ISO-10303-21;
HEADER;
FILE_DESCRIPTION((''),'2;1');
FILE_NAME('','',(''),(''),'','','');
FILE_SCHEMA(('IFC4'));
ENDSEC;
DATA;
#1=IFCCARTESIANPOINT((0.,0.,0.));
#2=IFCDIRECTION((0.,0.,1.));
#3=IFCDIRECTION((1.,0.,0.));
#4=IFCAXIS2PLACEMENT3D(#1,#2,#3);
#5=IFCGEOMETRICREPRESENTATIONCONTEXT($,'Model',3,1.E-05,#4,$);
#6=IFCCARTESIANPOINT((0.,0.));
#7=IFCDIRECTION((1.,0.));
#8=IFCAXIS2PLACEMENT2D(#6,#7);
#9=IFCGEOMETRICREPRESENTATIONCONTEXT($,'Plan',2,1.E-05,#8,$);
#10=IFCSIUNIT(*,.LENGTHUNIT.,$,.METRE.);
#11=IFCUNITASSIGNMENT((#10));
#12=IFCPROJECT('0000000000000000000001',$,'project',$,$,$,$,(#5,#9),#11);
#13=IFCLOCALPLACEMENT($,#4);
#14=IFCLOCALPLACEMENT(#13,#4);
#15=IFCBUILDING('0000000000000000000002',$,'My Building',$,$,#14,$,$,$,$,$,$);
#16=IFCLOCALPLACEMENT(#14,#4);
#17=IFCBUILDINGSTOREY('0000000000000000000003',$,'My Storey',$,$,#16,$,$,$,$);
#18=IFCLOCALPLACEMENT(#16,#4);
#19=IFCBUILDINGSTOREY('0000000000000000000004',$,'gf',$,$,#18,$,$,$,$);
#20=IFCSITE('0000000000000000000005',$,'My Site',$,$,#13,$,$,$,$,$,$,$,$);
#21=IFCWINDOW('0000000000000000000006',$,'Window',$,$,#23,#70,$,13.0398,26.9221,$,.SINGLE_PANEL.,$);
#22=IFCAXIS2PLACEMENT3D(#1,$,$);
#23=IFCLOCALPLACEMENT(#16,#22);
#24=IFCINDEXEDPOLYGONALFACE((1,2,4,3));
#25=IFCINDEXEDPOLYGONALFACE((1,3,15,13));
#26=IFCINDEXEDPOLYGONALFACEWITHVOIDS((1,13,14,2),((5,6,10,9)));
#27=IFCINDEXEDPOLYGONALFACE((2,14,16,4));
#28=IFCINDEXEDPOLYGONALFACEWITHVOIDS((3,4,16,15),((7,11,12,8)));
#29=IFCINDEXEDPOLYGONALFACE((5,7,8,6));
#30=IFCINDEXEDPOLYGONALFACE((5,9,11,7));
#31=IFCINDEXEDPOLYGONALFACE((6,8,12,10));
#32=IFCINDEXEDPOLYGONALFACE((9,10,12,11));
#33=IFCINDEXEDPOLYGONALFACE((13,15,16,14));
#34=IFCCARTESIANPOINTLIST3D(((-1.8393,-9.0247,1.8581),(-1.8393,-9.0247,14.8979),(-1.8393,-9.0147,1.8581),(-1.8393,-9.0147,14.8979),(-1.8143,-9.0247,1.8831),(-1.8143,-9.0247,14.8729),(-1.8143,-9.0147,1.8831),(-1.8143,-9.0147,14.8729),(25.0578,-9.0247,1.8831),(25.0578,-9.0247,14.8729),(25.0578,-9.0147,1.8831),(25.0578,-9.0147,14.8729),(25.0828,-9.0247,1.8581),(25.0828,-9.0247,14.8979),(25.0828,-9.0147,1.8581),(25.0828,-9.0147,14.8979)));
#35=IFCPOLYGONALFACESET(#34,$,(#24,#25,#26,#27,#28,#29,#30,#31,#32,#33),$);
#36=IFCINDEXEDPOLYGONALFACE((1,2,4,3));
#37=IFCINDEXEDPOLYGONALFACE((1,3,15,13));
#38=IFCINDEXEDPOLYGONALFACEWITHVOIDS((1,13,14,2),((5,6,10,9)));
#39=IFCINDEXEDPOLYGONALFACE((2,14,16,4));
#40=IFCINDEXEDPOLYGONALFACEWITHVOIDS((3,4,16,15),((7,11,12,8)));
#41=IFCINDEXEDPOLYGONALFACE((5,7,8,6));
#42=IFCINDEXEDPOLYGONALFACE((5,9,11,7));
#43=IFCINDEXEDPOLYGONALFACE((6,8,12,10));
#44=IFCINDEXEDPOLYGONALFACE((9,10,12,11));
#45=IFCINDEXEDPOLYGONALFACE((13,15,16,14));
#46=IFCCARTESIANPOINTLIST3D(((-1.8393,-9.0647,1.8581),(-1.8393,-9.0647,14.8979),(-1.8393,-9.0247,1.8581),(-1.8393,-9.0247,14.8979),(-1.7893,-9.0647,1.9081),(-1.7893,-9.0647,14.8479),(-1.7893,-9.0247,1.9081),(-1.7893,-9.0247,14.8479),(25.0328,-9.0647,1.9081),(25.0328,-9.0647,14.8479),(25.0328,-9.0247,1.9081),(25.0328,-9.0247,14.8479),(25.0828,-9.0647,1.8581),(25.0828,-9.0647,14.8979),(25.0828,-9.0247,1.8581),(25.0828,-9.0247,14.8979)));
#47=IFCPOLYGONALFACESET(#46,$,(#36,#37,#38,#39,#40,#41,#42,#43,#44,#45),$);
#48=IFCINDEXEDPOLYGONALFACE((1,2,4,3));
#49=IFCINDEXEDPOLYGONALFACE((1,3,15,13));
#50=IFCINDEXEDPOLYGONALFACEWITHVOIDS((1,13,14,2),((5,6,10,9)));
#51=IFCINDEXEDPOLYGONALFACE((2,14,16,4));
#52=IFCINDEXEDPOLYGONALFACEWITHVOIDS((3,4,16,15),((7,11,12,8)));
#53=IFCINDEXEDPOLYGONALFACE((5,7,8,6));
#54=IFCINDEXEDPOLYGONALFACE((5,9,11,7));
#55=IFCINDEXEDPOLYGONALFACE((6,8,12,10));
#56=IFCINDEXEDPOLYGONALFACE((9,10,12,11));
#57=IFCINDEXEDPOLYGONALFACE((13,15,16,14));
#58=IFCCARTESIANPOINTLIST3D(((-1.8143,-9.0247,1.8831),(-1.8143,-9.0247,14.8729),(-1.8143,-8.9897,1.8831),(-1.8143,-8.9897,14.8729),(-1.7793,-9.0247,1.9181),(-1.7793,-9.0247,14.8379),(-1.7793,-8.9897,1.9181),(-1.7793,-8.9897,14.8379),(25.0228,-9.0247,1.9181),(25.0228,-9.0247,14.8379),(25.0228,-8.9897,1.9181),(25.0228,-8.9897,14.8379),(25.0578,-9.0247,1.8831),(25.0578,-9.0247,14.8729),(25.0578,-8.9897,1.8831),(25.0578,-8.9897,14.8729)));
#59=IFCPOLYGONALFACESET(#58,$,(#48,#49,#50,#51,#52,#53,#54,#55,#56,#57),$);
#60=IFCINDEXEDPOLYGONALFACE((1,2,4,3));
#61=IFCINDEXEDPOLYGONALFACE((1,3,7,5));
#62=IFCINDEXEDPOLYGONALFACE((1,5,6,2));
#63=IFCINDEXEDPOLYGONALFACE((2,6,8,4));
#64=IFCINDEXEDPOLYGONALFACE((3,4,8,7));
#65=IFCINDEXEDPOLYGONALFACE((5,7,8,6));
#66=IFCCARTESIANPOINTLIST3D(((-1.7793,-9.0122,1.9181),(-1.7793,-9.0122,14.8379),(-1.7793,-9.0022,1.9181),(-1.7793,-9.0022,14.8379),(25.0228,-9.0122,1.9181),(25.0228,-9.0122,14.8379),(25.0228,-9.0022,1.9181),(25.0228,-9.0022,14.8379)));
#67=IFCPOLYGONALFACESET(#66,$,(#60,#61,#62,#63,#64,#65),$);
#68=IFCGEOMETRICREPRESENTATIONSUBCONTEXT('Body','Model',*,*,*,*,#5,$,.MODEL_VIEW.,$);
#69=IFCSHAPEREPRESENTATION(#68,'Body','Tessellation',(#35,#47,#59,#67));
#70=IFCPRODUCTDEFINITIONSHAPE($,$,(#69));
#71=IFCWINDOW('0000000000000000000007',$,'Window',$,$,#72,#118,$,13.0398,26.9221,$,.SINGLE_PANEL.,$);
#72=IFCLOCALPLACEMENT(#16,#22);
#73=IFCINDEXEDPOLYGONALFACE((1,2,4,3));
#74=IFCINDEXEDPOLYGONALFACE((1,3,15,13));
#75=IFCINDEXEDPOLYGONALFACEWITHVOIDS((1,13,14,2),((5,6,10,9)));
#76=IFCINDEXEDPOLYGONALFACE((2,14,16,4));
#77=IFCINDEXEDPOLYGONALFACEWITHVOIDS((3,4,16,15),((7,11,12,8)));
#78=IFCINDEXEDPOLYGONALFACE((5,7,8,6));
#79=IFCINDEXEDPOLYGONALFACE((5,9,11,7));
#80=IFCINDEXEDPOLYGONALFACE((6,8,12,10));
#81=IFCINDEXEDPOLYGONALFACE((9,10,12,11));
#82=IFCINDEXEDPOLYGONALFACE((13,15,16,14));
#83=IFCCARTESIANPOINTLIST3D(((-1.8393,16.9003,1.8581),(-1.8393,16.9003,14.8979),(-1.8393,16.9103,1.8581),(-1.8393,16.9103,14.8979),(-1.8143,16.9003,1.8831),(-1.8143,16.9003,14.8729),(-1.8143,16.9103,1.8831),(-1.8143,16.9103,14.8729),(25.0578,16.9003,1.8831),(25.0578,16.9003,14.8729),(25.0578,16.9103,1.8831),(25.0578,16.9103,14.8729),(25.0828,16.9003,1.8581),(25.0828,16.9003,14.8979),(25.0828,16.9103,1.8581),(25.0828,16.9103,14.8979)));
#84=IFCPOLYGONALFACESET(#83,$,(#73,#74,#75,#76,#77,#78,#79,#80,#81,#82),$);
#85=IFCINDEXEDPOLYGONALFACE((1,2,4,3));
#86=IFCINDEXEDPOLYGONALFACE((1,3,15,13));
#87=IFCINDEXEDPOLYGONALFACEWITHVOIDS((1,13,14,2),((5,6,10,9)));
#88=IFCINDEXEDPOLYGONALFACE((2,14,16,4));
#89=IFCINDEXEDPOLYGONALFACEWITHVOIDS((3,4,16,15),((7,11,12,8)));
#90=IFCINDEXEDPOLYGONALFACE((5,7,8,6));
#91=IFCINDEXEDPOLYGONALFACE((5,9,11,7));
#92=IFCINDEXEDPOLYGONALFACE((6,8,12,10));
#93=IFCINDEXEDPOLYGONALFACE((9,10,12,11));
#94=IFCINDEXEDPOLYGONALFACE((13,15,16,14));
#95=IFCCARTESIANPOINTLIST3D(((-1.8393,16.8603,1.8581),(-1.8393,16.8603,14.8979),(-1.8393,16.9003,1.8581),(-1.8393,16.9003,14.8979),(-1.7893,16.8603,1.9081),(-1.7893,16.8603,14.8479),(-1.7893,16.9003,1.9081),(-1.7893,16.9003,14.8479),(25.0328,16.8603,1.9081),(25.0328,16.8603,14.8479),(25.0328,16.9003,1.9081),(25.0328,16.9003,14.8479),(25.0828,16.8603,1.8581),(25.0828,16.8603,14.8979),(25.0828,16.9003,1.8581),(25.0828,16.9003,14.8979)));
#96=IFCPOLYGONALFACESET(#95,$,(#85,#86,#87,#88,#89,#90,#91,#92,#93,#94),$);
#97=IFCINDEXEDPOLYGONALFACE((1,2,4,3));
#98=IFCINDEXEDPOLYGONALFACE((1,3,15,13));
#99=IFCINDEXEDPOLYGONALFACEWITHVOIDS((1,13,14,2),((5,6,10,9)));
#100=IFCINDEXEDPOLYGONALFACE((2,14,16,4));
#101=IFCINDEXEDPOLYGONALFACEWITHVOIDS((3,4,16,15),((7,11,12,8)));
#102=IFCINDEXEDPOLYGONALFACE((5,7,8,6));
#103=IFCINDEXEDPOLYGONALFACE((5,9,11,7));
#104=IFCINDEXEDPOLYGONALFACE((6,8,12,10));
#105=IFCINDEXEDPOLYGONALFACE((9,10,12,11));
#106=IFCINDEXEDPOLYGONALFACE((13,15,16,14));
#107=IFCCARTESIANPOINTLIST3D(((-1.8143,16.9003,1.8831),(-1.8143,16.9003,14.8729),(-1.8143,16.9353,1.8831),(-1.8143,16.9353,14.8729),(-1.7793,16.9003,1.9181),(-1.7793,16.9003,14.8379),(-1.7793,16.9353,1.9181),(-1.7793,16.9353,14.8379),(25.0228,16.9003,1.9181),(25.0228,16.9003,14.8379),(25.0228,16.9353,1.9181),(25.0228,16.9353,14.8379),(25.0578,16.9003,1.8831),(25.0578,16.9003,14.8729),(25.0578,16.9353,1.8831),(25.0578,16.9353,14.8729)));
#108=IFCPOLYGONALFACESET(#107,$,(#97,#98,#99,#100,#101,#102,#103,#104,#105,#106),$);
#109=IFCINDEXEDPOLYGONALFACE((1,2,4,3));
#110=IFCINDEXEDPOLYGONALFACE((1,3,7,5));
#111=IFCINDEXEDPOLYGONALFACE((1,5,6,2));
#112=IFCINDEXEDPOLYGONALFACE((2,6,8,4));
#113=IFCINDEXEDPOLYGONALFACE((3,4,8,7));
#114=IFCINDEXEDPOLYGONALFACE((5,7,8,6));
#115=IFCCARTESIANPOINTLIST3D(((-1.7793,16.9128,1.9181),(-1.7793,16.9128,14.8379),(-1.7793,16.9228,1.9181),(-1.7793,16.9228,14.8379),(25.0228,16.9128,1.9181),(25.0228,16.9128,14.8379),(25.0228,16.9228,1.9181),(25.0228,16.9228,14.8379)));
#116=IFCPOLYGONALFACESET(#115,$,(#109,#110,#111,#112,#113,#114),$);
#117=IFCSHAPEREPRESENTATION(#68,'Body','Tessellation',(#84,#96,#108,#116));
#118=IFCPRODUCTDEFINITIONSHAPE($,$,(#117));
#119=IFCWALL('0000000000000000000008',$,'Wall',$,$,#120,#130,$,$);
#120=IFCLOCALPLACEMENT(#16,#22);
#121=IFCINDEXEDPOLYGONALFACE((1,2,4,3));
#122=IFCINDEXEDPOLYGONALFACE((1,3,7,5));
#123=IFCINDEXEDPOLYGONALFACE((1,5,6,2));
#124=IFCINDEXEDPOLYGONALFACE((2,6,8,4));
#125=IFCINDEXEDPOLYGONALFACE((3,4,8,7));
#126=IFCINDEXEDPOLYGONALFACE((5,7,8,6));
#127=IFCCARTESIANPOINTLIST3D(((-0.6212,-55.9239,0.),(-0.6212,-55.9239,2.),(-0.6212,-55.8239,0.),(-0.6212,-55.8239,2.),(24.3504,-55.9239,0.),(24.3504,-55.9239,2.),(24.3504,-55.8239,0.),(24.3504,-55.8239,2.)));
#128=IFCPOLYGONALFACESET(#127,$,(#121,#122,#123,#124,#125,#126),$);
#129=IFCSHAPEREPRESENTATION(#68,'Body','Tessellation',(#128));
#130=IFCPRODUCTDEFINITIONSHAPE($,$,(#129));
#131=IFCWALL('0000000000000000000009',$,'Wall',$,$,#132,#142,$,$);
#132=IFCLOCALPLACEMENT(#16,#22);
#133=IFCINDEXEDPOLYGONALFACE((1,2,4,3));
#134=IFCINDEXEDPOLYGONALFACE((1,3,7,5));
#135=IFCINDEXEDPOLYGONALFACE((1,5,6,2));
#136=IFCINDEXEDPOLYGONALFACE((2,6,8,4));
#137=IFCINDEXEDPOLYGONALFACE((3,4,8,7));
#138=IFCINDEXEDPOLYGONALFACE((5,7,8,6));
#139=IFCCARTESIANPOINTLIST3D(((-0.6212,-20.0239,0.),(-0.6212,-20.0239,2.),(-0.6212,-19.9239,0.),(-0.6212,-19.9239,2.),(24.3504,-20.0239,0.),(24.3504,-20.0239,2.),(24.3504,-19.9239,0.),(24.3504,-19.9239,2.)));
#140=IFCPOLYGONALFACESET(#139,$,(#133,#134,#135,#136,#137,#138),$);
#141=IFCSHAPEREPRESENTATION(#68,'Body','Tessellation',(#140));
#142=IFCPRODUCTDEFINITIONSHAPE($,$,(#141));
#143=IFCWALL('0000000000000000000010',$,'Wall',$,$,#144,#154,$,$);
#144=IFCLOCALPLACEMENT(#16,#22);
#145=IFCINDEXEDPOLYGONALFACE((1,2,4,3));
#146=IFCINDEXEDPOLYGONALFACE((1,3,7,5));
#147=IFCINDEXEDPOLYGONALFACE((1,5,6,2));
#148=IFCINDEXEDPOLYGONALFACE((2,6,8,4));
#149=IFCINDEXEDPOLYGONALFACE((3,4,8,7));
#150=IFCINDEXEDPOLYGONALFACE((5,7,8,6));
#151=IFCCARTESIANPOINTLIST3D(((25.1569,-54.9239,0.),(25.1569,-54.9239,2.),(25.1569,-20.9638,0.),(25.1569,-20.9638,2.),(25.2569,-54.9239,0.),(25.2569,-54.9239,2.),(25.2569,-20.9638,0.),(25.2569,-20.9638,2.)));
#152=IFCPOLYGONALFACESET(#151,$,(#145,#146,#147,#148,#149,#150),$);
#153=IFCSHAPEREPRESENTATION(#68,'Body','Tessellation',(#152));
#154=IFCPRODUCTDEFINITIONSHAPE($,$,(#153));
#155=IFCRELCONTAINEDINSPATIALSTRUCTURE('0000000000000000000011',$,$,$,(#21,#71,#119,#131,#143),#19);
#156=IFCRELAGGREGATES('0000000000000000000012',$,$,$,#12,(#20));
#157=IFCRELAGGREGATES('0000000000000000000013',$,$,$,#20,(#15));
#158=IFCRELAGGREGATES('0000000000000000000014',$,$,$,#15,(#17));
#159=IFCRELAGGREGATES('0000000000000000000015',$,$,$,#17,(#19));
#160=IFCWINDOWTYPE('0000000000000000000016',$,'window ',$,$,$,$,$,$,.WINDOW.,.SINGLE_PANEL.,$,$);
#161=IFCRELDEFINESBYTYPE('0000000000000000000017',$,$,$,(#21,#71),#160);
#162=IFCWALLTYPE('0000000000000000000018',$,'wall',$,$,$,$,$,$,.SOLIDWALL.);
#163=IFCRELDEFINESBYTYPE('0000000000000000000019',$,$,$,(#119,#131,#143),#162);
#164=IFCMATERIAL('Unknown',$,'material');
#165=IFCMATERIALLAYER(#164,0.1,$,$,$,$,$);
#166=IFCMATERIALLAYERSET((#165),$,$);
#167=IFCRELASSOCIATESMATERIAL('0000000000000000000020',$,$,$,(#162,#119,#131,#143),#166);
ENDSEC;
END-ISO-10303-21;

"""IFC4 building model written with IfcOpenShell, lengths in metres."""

from ifc_helpers import new_model, entity, si_unit, frame, origin_with_axes, origin_2d_with_axis, place, context, subcontext, project, spatial, line, indexed_curve, outline, extrude, shape, source, transform, mapped, material, layer, layer_set, layer_usage, type_object, type_shapes, element, save


model = new_model("IFC4")

# Units and contexts
model_context = context("Model", 3, precision=1e-05, world=origin_with_axes())
plan_context = context("Plan", 2, precision=1e-05, world=origin_2d_with_axis())
body_context_1 = subcontext(model_context, "Body", "Model", "MODEL_VIEW")
body_context_2 = subcontext(plan_context, "Body", "Plan", "PLAN_VIEW")
ifc_project = project(units=[si_unit("LENGTHUNIT", "METRE")], contexts=[model_context, plan_context])

# Site, building, storeys
site_placement = place(None, origin_with_axes())
site = spatial("IfcSite", under=ifc_project, at=site_placement, Name="My Site")
building_placement = place(site_placement, origin_with_axes())
building = spatial("IfcBuilding", under=site, at=building_placement, Name="My Building")
storey_1_placement = place(building_placement, origin_with_axes())
storey_1 = spatial("IfcBuildingStorey", under=building, at=storey_1_placement, Name="My Storey")
storey_2_placement = place(storey_1_placement, origin_with_axes())
storey_2 = spatial("IfcBuildingStorey", under=storey_1, at=storey_2_placement, Name="gf")

# Shared definitions
ifc_material = material(Name="Unknown", Category="material")

# Windows
window_type = type_object("IfcWindowType", Name="window ", PartitioningType="SINGLE_PANEL", PredefinedType="WINDOW")
shared_shape_1 = source(origin_with_axes(), body_context_1, "Body", "SweptSolid", [
    extrude(outline(indexed_curve([(0.0, 0.0), (26.9221, 0.0), (26.9221, 13.0398), (0.0, 13.0398)], segments=[line(1, 2, 3, 4, 1)]), holes=[indexed_curve([(0.025, 0.025), (26.8971, 0.025), (26.8971, 13.0148), (0.025, 13.0148)], segments=[line(1, 2, 3, 4, 1)])]), frame((0.0, 0.09, 0.0), z_axis=(0.0, -1.0, 0.0), x_axis=(1.0, 0.0, 0.0)), (0.0, 0.0, -1.0), 0.01),
    extrude(outline(indexed_curve([(0.0, 0.0), (26.9221, 0.0), (26.9221, 13.0398), (0.0, 13.0398)], segments=[line(1, 2, 3, 4, 1)]), holes=[indexed_curve([(0.05, 0.05), (26.8721, 0.05), (26.8721, 12.9898), (0.05, 12.9898)], segments=[line(1, 2, 3, 4, 1)])]), frame((0.0, 0.05, 0.0), z_axis=(0.0, -1.0, 0.0), x_axis=(1.0, 0.0, 0.0)), (0.0, 0.0, -1.0), 0.04),
    extrude(outline(indexed_curve([(0.0, 0.0), (26.8721, 0.0), (26.8721, 12.9898), (0.0, 12.9898)], segments=[line(1, 2, 3, 4, 1)]), holes=[indexed_curve([(0.035, 0.035), (26.8371, 0.035), (26.8371, 12.9548), (0.035, 12.9548)], segments=[line(1, 2, 3, 4, 1)])]), frame((0.025, 0.09, 0.025), z_axis=(0.0, -1.0, 0.0), x_axis=(1.0, 0.0, 0.0)), (0.0, 0.0, -1.0), 0.035),
    extrude(outline(indexed_curve([(0.035, 0.035), (26.8371, 0.035), (26.8371, 12.9548), (0.035, 12.9548)], segments=[line(1, 2, 3, 4, 1)])), frame((0.025, 0.1025, 0.025), z_axis=(0.0, -1.0, 0.0), x_axis=(1.0, 0.0, 0.0)), (0.0, 0.0, -1.0), 0.01),
])
shared_shape_2 = source(origin_with_axes(), body_context_2, "Body", "Curve2D", [
    entity("IfcIndexedPolyCurve", entity("IfcCartesianPointList2D", [[0.05, 0.05], [26.8721, 0.05]])),
    entity("IfcIndexedPolyCurve", entity("IfcCartesianPointList2D", [[0.0, 0.1], [0.025, 0.1], [0.025, 0.09], [0.05, 0.09], [0.05, 0.05], [0.0, 0.05]]), [entity("IfcLineIndex", [1, 2, 3, 4, 5, 6, 1])]),
    entity("IfcIndexedPolyCurve", entity("IfcCartesianPointList2D", [[26.9221, 0.1], [26.8971, 0.1], [26.8971, 0.09], [26.8721, 0.09], [26.8721, 0.05], [26.9221, 0.05]]), [entity("IfcLineIndex", [1, 2, 3, 4, 5, 6, 1])]),
    entity("IfcIndexedPolyCurve", entity("IfcCartesianPointList2D", [[0.025, 0.09], [0.06, 0.09], [0.06, 0.125], [0.025, 0.125]]), [entity("IfcLineIndex", [1, 2, 3, 4, 1])]),
    entity("IfcIndexedPolyCurve", entity("IfcCartesianPointList2D", [[26.8971, 0.09], [26.8621, 0.09], [26.8621, 0.125], [26.8971, 0.125]]), [entity("IfcLineIndex", [1, 2, 3, 4, 1])]),
    entity("IfcIndexedPolyCurve", entity("IfcCartesianPointList2D", [[0.06, 0.09], [26.8621, 0.09]])),
    entity("IfcIndexedPolyCurve", entity("IfcCartesianPointList2D", [[0.06, 0.125], [26.8621, 0.125]])),
    entity("IfcIndexedPolyCurve", entity("IfcCartesianPointList2D", [[0.06, 0.1075], [26.8621, 0.1075]])),
])
type_shapes(window_type, [shared_shape_1, shared_shape_2])
for number, where, z_axis, x_axis, name in (
    (1, (-1.8393, -9.1147, 1.8581), (0.0, 0.0, 1.0), (1.0, 0.0, 0.0), "Window"),
    (2, (-1.8393, 16.8103, 1.8581), (0.0, 0.0, 1.0), (1.0, 0.0, 0.0), "Window"),
):
    element("IfcWindow", number, at=place(storey_2_placement, frame(where, z_axis=z_axis, x_axis=x_axis)), inside=storey_2, type_object=window_type, Name=name, OverallHeight=13.0398, OverallWidth=26.9221, PartitioningType="SINGLE_PANEL", shapes=[
        shape(body_context_1, "Body", "MappedRepresentation", [mapped(shared_shape_1, transform((0.0, 0.0, 0.0), x_axis=(1.0, 0.0, 0.0), y_axis=(0.0, 1.0, 0.0), z_axis=(0.0, 0.0, 1.0), scale=1.0))]),
        shape(body_context_2, "Body", "MappedRepresentation", [mapped(shared_shape_2, transform((0.0, 0.0, 0.0), x_axis=(1.0, 0.0, 0.0), y_axis=(0.0, 1.0, 0.0), z_axis=(0.0, 0.0, 1.0), scale=1.0))]),
    ])

# Walls
ifc_layer_1 = layer(ifc_material, 0.1)
ifc_layer_set_1 = layer_set([ifc_layer_1])
ifc_layer_usage_1 = layer_usage(ifc_layer_set_1, "AXIS2", "POSITIVE", 0.0)
wall_type = type_object("IfcWallType", Name="wall", PredefinedType="SOLIDWALL", material=ifc_layer_set_1)
wall_1_placement = place(storey_2_placement, frame((-0.6212, -55.9239, 0.0), z_axis=(0.0, 0.0, 1.0), x_axis=(1.0, 0.0, 0.0)))
element("IfcWall", 3, at=wall_1_placement, inside=storey_2, type_object=wall_type, material=ifc_layer_usage_1, Name="Wall", context=body_context_1, shape_type="SweptSolid", body=[
    extrude(outline(indexed_curve([(0.0, 0.0), (0.0, 0.1), (24.9716, 0.1), (24.9716, 0.0)], segments=[line(1, 2, 3, 4, 1)])), origin_with_axes(), (0.0, 0.0, 1.0), 2.0),
])
ifc_layer_usage_2 = layer_usage(ifc_layer_set_1, "AXIS2", "POSITIVE", 0.0)
wall_2_placement = place(storey_2_placement, frame((-0.6212, -20.0239, 0.0), z_axis=(0.0, 0.0, 1.0), x_axis=(1.0, 0.0, 0.0)))
element("IfcWall", 4, at=wall_2_placement, inside=storey_2, type_object=wall_type, material=ifc_layer_usage_2, Name="Wall", context=body_context_1, shape_type="SweptSolid", body=[
    extrude(outline(indexed_curve([(0.0, 0.0), (0.0, 0.1), (24.9716, 0.1), (24.9716, 0.0)], segments=[line(1, 2, 3, 4, 1)])), origin_with_axes(), (0.0, 0.0, 1.0), 2.0),
])
ifc_layer_usage_3 = layer_usage(ifc_layer_set_1, "AXIS2", "POSITIVE", 0.0)
wall_3_placement = place(storey_2_placement, frame((25.2569, -54.9239, 0.0), z_axis=(0.0, 0.0, 1.0), x_axis=(0.0, 1.0, 0.0)))
element("IfcWall", 5, at=wall_3_placement, inside=storey_2, type_object=wall_type, material=ifc_layer_usage_3, Name="Wall", context=body_context_1, shape_type="SweptSolid", body=[
    extrude(outline(indexed_curve([(0.0, 0.0), (0.0, 0.1), (33.9601, 0.1), (33.9601, 0.0)], segments=[line(1, 2, 3, 4, 1)])), origin_with_axes(), (0.0, 0.0, 1.0), 2.0),
])

save(model, "model.ifc")
